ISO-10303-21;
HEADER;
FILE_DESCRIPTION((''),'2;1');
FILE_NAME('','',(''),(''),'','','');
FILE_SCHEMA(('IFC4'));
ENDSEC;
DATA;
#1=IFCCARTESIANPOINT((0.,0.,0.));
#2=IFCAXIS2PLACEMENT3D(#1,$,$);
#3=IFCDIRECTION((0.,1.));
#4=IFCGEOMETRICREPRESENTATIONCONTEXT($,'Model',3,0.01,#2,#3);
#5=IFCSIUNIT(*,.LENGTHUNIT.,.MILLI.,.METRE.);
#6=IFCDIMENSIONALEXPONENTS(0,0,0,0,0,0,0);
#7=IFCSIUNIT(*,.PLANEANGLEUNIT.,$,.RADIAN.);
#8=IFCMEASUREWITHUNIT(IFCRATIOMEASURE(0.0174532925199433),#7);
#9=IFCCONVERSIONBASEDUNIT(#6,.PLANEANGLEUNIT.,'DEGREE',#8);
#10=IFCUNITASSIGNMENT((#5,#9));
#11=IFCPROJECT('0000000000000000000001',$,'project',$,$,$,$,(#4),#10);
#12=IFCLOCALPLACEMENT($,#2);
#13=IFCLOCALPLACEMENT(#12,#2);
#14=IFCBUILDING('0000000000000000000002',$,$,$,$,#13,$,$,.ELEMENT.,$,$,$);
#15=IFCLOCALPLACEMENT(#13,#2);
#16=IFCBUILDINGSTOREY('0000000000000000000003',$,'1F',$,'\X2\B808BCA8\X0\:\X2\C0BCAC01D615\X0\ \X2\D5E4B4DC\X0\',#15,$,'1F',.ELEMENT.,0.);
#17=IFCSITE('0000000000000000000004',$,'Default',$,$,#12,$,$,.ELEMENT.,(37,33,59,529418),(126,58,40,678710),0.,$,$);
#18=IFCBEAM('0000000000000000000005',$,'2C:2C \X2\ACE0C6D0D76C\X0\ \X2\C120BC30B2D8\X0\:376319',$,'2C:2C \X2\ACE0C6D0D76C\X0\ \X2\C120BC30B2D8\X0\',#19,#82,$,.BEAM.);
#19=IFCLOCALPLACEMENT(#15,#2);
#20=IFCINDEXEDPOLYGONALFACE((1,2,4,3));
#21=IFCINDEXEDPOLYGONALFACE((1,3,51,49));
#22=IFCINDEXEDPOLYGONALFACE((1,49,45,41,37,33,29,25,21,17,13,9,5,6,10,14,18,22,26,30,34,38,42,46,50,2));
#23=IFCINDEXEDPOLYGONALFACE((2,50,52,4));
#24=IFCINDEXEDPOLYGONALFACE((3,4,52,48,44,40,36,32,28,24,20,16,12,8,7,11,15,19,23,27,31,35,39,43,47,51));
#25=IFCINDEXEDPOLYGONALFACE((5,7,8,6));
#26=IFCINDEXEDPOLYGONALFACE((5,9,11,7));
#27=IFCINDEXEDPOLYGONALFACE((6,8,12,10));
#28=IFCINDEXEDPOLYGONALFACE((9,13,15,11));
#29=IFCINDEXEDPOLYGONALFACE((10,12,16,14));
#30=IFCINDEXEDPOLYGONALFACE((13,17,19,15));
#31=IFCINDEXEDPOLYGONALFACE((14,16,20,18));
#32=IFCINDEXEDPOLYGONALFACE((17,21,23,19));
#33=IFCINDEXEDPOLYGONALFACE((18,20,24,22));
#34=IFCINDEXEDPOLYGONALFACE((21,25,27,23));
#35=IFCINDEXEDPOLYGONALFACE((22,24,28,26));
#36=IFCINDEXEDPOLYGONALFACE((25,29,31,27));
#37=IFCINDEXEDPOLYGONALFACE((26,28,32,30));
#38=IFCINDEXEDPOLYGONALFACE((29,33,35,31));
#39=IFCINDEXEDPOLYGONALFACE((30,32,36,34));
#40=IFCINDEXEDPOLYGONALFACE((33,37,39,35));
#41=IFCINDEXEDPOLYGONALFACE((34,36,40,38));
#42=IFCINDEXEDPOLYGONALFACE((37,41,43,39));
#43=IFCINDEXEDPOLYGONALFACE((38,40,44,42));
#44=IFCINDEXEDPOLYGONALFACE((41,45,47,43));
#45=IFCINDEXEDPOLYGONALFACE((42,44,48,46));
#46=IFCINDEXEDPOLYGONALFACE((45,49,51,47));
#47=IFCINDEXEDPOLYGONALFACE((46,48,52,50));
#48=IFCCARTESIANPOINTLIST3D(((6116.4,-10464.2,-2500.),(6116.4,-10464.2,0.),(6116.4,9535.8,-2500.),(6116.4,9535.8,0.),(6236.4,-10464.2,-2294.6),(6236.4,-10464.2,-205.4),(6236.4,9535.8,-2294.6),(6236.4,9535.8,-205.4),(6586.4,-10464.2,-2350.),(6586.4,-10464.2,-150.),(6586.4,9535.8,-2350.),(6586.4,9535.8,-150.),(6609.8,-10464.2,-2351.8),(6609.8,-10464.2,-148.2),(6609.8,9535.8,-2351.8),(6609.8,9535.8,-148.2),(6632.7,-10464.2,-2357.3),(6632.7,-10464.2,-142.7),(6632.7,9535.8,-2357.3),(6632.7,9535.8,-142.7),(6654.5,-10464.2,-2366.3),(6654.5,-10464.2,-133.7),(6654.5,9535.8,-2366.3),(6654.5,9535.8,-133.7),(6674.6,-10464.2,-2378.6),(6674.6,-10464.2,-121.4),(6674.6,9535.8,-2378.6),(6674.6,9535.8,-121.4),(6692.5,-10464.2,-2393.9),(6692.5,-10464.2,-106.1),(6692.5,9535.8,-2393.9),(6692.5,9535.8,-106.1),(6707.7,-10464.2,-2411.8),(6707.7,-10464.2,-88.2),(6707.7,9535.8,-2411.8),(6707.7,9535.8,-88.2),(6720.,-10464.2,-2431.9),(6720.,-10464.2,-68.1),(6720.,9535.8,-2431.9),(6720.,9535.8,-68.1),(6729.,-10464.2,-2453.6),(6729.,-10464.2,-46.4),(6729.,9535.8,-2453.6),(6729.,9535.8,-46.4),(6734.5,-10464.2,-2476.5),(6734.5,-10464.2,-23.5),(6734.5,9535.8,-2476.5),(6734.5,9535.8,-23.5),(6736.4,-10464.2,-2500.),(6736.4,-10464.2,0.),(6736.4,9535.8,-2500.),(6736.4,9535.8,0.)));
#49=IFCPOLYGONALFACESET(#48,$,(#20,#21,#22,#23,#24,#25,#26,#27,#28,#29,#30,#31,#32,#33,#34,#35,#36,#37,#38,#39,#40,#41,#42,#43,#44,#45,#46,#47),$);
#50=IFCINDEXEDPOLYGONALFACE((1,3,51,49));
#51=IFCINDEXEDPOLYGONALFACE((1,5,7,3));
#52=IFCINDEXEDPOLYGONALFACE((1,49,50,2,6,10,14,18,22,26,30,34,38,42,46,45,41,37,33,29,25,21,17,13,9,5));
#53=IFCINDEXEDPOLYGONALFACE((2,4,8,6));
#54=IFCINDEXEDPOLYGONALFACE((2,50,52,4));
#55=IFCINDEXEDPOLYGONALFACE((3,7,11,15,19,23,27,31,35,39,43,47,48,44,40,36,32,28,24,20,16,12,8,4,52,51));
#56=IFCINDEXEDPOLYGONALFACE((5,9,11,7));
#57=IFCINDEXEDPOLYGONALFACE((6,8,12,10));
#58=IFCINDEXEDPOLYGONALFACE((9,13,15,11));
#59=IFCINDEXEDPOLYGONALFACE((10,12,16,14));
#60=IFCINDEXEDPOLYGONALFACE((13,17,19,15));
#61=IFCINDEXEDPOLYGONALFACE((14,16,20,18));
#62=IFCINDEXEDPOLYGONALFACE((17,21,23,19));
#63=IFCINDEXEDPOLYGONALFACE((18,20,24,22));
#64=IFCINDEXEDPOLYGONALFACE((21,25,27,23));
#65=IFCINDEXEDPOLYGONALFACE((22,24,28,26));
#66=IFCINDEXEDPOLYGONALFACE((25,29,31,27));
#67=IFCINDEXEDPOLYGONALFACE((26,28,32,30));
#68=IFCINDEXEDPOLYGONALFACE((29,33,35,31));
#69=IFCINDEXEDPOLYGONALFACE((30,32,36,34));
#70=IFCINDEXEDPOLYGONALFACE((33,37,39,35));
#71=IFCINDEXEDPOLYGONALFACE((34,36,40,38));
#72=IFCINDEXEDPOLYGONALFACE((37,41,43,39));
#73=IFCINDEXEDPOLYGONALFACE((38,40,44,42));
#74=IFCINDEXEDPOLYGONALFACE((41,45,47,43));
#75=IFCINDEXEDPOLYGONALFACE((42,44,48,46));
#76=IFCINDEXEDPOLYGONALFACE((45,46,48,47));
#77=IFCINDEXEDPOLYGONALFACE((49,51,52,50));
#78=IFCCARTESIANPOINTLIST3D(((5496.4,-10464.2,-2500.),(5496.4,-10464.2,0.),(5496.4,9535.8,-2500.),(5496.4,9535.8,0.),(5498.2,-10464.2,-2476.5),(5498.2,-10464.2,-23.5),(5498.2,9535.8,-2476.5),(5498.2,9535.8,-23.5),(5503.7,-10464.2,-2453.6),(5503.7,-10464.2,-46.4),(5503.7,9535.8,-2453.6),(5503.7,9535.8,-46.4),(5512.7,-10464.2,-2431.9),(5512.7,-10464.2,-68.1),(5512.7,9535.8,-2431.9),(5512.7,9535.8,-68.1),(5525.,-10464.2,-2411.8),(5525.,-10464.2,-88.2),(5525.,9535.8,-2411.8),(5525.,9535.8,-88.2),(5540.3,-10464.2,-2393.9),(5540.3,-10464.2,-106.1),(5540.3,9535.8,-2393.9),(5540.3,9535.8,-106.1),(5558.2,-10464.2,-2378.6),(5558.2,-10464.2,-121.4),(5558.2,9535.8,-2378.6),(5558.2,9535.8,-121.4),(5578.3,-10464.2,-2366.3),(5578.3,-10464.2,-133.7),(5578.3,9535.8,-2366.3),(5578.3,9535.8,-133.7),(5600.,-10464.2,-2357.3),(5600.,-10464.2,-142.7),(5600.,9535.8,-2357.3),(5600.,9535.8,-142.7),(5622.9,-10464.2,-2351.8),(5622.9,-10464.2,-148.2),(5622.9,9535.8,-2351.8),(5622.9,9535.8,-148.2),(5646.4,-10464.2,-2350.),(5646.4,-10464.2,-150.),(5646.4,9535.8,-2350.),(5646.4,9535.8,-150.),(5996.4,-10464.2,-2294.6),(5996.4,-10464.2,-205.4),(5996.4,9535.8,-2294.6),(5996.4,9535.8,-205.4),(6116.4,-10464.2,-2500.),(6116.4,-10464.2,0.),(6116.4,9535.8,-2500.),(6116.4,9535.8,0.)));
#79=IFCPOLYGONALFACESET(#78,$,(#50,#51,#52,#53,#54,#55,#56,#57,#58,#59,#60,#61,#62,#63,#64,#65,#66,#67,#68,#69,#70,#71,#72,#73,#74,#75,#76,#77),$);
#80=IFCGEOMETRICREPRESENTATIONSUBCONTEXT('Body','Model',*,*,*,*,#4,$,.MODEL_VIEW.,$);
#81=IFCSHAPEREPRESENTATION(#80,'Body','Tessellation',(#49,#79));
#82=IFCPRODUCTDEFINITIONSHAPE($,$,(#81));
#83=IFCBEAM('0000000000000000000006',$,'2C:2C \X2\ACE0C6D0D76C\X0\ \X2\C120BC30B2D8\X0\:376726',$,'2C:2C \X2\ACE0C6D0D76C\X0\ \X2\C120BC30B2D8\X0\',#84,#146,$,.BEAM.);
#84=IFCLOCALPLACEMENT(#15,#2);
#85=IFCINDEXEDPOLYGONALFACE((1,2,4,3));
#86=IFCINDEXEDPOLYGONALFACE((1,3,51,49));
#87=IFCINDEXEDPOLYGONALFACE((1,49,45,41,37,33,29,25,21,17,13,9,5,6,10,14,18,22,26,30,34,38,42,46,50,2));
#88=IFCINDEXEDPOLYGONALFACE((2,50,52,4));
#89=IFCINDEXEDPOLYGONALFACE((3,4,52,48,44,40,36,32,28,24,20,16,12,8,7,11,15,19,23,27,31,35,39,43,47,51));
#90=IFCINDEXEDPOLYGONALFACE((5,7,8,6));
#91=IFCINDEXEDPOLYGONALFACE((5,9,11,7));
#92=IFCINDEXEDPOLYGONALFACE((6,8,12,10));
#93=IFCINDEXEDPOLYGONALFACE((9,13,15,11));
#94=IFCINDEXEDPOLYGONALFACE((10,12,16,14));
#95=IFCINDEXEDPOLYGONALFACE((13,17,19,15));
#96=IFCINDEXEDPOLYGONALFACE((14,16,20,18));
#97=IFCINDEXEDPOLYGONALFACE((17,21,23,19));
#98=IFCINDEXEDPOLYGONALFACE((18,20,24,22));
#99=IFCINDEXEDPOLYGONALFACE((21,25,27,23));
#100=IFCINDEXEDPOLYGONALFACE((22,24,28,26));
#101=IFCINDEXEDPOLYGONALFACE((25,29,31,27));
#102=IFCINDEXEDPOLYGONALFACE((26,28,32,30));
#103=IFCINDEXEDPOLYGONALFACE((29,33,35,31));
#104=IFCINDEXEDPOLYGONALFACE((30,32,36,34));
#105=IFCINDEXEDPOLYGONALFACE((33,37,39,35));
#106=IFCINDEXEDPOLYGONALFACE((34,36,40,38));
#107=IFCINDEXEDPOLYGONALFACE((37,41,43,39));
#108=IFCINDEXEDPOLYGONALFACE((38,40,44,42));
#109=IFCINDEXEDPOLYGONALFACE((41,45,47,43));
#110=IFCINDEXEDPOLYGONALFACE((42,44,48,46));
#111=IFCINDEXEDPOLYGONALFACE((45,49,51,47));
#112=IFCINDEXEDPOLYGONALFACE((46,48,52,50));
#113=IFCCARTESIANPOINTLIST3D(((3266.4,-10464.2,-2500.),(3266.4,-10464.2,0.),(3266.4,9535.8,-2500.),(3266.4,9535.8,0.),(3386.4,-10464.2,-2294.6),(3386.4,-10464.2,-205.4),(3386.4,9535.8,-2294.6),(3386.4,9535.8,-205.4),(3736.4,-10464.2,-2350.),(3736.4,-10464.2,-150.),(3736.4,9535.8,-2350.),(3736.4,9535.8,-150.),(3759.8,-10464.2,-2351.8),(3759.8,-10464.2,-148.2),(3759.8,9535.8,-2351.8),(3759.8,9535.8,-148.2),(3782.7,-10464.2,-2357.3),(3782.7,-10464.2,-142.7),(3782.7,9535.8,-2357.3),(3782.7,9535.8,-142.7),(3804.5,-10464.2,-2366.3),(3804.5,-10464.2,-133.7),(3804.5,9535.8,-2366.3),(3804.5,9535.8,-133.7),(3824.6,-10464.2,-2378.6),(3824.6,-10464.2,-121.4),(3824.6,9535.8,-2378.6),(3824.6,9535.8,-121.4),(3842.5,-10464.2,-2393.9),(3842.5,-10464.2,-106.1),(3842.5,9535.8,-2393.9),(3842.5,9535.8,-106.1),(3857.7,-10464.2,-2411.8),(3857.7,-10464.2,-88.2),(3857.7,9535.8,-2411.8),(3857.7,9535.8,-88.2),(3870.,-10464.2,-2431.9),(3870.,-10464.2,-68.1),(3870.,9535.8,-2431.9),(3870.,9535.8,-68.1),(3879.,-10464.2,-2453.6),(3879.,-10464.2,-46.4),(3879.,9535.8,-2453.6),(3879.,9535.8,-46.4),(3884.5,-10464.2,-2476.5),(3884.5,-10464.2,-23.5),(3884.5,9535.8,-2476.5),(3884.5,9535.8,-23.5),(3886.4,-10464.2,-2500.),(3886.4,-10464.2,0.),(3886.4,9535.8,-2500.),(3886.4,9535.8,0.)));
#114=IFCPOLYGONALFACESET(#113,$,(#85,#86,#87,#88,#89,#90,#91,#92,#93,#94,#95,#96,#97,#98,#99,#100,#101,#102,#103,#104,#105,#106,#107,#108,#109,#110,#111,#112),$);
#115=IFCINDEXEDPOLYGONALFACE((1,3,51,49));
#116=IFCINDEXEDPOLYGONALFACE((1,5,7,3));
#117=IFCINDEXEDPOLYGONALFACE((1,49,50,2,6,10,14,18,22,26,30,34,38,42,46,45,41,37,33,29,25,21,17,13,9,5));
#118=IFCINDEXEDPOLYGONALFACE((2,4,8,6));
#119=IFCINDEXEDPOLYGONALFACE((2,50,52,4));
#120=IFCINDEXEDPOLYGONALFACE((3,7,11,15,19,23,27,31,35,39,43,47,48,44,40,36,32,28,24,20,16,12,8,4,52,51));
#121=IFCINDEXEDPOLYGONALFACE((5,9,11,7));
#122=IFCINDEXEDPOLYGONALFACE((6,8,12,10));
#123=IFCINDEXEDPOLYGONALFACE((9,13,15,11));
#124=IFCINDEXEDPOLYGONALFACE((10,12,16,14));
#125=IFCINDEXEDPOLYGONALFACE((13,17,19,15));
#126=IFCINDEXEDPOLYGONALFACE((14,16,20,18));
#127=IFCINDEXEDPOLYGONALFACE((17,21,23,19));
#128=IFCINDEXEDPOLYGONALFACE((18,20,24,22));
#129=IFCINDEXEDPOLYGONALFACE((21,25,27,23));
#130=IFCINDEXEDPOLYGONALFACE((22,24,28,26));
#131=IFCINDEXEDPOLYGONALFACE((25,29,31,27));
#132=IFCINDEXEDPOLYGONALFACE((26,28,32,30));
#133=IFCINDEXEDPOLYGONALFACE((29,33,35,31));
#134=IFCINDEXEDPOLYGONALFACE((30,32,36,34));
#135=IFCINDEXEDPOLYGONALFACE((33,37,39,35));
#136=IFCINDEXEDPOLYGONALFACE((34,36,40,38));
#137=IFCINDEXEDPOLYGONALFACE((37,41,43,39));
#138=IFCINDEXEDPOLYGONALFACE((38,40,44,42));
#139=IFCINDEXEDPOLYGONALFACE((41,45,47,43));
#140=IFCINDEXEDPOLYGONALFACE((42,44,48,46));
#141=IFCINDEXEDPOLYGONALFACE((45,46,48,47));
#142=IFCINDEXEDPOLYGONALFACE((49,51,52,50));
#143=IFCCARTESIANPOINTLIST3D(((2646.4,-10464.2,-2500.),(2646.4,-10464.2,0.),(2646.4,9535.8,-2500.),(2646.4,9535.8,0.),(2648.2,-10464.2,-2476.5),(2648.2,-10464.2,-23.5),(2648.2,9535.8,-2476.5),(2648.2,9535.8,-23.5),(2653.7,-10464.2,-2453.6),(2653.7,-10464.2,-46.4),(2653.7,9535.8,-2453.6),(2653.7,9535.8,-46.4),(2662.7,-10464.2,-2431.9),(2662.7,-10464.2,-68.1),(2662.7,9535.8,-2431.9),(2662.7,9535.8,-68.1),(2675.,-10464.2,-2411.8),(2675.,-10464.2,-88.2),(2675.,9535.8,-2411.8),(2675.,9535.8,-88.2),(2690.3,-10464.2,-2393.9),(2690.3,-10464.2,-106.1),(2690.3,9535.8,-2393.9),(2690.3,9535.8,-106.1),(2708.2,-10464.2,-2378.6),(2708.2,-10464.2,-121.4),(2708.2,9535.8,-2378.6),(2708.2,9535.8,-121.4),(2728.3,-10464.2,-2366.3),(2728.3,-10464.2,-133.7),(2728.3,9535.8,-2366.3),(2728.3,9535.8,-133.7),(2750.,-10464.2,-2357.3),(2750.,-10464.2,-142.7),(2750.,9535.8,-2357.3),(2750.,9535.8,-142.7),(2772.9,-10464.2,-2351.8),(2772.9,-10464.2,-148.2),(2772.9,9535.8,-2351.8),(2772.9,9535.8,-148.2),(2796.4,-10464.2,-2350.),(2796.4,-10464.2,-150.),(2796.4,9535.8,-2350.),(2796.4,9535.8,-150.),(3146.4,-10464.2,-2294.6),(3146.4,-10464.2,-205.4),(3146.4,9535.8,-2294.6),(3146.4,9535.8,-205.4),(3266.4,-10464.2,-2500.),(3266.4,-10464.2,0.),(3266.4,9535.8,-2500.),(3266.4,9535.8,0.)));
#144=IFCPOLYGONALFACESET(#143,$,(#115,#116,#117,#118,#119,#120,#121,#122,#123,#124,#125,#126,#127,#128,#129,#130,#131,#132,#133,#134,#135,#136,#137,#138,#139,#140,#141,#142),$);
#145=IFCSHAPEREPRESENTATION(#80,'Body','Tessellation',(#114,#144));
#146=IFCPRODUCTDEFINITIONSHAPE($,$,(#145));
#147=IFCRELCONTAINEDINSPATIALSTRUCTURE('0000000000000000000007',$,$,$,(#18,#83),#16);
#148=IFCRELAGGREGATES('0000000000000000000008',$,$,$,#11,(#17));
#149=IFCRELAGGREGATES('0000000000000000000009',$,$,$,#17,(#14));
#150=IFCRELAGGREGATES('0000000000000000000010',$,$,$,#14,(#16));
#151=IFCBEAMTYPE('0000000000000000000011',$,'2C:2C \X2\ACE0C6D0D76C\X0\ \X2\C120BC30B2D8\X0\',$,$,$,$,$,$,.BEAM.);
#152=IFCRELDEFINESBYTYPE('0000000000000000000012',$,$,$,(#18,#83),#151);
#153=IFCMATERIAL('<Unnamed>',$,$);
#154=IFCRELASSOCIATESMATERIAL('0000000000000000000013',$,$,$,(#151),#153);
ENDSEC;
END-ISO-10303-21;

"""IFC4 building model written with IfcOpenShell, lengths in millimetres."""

from ifc_helpers import new_model, entity, si_unit, converted_unit, direction, frame, origin, place, context, subcontext, project, spatial, indexed_curve, outline, extrude, source, transform, mapped, material, type_object, type_shapes, element, save


model = new_model("IFC4")

# Units and contexts
model_context = context("Model", 3, precision=0.01, world=origin(), true_north=direction((0.0, 1.0)))
body_context = subcontext(model_context, "Body", "Model", "MODEL_VIEW")
ifc_project = project(units=[si_unit("LENGTHUNIT", "METRE", prefix="MILLI"), converted_unit("PLANEANGLEUNIT", "DEGREE", entity("IfcRatioMeasure", 0.0174532925199433), si_unit("PLANEANGLEUNIT", "RADIAN"), dimensions=[0, 0, 0, 0, 0, 0, 0])], contexts=[model_context])

# Site, building, storey
site_placement = place(None, origin())
site = spatial("IfcSite", under=ifc_project, at=site_placement, Name="Default", CompositionType="ELEMENT", RefLatitude=(37, 33, 59, 529418), RefLongitude=(126, 58, 40, 678710), RefElevation=0.0)
building_placement = place(site_placement, origin())
building = spatial("IfcBuilding", under=site, at=building_placement, CompositionType="ELEMENT")
storey_placement = place(building_placement, origin())
storey = spatial("IfcBuildingStorey", under=building, at=storey_placement, Name="1F", ObjectType="레벨:삼각형 헤드", LongName="1F", CompositionType="ELEMENT", Elevation=0.0)

# Beams
ifc_material = material(Name="<Unnamed>")
beam_type_1 = type_object("IfcBeamType", Name="2C:2C 고원희 선배님", PredefinedType="BEAM", material=ifc_material)
shared_shape_1 = source(origin(), body_context, "Body", "SweptSolid", [
    extrude(outline(indexed_curve([(-1250.0, -302.5), (1250.0, -302.5), (1250.0, 317.5), (1226.5, 315.7), (1203.6, 310.2), (1181.9, 301.2), (1161.8, 288.9), (1143.9, 273.6), (1128.6, 255.7), (1116.3, 235.6), (1107.3, 213.9), (1101.8, 191.0), (1100.0, 167.5), (1044.6, -182.5), (-1044.6, -182.5), (-1100.0, 167.5), (-1101.8, 191.0), (-1107.3, 213.9), (-1116.3, 235.6), (-1128.6, 255.7), (-1143.9, 273.6), (-1161.8, 288.9), (-1181.9, 301.2), (-1203.6, 310.2), (-1226.5, 315.7), (-1250.0, 317.5), (-1250.0, -302.5)], self_intersect=False)), frame((-10000.0, 302.5, 0.0), z_axis=(1.0, 0.0, 0.0), x_axis=(0.0, 0.0, -1.0)), (0.0, 0.0, 1.0), 20000.0),
    extrude(outline(indexed_curve([(-317.5, -1250.0), (302.5, -1250.0), (302.5, 1250.0), (-317.5, 1250.0), (-315.7, 1226.5), (-310.2, 1203.6), (-301.2, 1181.9), (-288.9, 1161.8), (-273.6, 1143.9), (-255.7, 1128.6), (-235.6, 1116.3), (-213.9, 1107.3), (-191.0, 1101.8), (-167.5, 1100.0), (182.5, 1044.6), (182.5, -1044.6), (-167.5, -1100.0), (-191.0, -1101.8), (-213.9, -1107.3), (-235.6, -1116.3), (-255.7, -1128.6), (-273.6, -1143.9), (-288.9, -1161.8), (-301.2, -1181.9), (-310.2, -1203.6), (-315.7, -1226.5), (-317.5, -1250.0)], self_intersect=False)), frame((-10000.0, -302.5, 0.0), z_axis=(1.0, 0.0, 0.0), x_axis=(0.0, 1.0, 0.0)), (0.0, 0.0, 1.0), 20000.0),
])
type_shapes(beam_type_1, [shared_shape_1])
for number, where, z_axis, x_axis, name in (
    (1, (6116.4, -464.2, -1250.0), (0.0, 0.0, 1.0), (0.0, -1.0, 0.0), "2C:2C 고원희 선배님:376319"),
    (2, (3266.4, -464.2, -1250.0), (0.0, 0.0, 1.0), (0.0, -1.0, 0.0), "2C:2C 고원희 선배님:376726"),
):
    element("IfcBeam", number, at=place(storey_placement, frame(where, z_axis=z_axis, x_axis=x_axis)), inside=storey, type_object=beam_type_1, Name=name, ObjectType="2C:2C 고원희 선배님", PredefinedType="BEAM", context=body_context, shape_type="MappedRepresentation", body=[
        mapped(shared_shape_1, transform((0.0, 0.0, 0.0), scale=1.0)),
    ])

save(model, "model.ifc")
